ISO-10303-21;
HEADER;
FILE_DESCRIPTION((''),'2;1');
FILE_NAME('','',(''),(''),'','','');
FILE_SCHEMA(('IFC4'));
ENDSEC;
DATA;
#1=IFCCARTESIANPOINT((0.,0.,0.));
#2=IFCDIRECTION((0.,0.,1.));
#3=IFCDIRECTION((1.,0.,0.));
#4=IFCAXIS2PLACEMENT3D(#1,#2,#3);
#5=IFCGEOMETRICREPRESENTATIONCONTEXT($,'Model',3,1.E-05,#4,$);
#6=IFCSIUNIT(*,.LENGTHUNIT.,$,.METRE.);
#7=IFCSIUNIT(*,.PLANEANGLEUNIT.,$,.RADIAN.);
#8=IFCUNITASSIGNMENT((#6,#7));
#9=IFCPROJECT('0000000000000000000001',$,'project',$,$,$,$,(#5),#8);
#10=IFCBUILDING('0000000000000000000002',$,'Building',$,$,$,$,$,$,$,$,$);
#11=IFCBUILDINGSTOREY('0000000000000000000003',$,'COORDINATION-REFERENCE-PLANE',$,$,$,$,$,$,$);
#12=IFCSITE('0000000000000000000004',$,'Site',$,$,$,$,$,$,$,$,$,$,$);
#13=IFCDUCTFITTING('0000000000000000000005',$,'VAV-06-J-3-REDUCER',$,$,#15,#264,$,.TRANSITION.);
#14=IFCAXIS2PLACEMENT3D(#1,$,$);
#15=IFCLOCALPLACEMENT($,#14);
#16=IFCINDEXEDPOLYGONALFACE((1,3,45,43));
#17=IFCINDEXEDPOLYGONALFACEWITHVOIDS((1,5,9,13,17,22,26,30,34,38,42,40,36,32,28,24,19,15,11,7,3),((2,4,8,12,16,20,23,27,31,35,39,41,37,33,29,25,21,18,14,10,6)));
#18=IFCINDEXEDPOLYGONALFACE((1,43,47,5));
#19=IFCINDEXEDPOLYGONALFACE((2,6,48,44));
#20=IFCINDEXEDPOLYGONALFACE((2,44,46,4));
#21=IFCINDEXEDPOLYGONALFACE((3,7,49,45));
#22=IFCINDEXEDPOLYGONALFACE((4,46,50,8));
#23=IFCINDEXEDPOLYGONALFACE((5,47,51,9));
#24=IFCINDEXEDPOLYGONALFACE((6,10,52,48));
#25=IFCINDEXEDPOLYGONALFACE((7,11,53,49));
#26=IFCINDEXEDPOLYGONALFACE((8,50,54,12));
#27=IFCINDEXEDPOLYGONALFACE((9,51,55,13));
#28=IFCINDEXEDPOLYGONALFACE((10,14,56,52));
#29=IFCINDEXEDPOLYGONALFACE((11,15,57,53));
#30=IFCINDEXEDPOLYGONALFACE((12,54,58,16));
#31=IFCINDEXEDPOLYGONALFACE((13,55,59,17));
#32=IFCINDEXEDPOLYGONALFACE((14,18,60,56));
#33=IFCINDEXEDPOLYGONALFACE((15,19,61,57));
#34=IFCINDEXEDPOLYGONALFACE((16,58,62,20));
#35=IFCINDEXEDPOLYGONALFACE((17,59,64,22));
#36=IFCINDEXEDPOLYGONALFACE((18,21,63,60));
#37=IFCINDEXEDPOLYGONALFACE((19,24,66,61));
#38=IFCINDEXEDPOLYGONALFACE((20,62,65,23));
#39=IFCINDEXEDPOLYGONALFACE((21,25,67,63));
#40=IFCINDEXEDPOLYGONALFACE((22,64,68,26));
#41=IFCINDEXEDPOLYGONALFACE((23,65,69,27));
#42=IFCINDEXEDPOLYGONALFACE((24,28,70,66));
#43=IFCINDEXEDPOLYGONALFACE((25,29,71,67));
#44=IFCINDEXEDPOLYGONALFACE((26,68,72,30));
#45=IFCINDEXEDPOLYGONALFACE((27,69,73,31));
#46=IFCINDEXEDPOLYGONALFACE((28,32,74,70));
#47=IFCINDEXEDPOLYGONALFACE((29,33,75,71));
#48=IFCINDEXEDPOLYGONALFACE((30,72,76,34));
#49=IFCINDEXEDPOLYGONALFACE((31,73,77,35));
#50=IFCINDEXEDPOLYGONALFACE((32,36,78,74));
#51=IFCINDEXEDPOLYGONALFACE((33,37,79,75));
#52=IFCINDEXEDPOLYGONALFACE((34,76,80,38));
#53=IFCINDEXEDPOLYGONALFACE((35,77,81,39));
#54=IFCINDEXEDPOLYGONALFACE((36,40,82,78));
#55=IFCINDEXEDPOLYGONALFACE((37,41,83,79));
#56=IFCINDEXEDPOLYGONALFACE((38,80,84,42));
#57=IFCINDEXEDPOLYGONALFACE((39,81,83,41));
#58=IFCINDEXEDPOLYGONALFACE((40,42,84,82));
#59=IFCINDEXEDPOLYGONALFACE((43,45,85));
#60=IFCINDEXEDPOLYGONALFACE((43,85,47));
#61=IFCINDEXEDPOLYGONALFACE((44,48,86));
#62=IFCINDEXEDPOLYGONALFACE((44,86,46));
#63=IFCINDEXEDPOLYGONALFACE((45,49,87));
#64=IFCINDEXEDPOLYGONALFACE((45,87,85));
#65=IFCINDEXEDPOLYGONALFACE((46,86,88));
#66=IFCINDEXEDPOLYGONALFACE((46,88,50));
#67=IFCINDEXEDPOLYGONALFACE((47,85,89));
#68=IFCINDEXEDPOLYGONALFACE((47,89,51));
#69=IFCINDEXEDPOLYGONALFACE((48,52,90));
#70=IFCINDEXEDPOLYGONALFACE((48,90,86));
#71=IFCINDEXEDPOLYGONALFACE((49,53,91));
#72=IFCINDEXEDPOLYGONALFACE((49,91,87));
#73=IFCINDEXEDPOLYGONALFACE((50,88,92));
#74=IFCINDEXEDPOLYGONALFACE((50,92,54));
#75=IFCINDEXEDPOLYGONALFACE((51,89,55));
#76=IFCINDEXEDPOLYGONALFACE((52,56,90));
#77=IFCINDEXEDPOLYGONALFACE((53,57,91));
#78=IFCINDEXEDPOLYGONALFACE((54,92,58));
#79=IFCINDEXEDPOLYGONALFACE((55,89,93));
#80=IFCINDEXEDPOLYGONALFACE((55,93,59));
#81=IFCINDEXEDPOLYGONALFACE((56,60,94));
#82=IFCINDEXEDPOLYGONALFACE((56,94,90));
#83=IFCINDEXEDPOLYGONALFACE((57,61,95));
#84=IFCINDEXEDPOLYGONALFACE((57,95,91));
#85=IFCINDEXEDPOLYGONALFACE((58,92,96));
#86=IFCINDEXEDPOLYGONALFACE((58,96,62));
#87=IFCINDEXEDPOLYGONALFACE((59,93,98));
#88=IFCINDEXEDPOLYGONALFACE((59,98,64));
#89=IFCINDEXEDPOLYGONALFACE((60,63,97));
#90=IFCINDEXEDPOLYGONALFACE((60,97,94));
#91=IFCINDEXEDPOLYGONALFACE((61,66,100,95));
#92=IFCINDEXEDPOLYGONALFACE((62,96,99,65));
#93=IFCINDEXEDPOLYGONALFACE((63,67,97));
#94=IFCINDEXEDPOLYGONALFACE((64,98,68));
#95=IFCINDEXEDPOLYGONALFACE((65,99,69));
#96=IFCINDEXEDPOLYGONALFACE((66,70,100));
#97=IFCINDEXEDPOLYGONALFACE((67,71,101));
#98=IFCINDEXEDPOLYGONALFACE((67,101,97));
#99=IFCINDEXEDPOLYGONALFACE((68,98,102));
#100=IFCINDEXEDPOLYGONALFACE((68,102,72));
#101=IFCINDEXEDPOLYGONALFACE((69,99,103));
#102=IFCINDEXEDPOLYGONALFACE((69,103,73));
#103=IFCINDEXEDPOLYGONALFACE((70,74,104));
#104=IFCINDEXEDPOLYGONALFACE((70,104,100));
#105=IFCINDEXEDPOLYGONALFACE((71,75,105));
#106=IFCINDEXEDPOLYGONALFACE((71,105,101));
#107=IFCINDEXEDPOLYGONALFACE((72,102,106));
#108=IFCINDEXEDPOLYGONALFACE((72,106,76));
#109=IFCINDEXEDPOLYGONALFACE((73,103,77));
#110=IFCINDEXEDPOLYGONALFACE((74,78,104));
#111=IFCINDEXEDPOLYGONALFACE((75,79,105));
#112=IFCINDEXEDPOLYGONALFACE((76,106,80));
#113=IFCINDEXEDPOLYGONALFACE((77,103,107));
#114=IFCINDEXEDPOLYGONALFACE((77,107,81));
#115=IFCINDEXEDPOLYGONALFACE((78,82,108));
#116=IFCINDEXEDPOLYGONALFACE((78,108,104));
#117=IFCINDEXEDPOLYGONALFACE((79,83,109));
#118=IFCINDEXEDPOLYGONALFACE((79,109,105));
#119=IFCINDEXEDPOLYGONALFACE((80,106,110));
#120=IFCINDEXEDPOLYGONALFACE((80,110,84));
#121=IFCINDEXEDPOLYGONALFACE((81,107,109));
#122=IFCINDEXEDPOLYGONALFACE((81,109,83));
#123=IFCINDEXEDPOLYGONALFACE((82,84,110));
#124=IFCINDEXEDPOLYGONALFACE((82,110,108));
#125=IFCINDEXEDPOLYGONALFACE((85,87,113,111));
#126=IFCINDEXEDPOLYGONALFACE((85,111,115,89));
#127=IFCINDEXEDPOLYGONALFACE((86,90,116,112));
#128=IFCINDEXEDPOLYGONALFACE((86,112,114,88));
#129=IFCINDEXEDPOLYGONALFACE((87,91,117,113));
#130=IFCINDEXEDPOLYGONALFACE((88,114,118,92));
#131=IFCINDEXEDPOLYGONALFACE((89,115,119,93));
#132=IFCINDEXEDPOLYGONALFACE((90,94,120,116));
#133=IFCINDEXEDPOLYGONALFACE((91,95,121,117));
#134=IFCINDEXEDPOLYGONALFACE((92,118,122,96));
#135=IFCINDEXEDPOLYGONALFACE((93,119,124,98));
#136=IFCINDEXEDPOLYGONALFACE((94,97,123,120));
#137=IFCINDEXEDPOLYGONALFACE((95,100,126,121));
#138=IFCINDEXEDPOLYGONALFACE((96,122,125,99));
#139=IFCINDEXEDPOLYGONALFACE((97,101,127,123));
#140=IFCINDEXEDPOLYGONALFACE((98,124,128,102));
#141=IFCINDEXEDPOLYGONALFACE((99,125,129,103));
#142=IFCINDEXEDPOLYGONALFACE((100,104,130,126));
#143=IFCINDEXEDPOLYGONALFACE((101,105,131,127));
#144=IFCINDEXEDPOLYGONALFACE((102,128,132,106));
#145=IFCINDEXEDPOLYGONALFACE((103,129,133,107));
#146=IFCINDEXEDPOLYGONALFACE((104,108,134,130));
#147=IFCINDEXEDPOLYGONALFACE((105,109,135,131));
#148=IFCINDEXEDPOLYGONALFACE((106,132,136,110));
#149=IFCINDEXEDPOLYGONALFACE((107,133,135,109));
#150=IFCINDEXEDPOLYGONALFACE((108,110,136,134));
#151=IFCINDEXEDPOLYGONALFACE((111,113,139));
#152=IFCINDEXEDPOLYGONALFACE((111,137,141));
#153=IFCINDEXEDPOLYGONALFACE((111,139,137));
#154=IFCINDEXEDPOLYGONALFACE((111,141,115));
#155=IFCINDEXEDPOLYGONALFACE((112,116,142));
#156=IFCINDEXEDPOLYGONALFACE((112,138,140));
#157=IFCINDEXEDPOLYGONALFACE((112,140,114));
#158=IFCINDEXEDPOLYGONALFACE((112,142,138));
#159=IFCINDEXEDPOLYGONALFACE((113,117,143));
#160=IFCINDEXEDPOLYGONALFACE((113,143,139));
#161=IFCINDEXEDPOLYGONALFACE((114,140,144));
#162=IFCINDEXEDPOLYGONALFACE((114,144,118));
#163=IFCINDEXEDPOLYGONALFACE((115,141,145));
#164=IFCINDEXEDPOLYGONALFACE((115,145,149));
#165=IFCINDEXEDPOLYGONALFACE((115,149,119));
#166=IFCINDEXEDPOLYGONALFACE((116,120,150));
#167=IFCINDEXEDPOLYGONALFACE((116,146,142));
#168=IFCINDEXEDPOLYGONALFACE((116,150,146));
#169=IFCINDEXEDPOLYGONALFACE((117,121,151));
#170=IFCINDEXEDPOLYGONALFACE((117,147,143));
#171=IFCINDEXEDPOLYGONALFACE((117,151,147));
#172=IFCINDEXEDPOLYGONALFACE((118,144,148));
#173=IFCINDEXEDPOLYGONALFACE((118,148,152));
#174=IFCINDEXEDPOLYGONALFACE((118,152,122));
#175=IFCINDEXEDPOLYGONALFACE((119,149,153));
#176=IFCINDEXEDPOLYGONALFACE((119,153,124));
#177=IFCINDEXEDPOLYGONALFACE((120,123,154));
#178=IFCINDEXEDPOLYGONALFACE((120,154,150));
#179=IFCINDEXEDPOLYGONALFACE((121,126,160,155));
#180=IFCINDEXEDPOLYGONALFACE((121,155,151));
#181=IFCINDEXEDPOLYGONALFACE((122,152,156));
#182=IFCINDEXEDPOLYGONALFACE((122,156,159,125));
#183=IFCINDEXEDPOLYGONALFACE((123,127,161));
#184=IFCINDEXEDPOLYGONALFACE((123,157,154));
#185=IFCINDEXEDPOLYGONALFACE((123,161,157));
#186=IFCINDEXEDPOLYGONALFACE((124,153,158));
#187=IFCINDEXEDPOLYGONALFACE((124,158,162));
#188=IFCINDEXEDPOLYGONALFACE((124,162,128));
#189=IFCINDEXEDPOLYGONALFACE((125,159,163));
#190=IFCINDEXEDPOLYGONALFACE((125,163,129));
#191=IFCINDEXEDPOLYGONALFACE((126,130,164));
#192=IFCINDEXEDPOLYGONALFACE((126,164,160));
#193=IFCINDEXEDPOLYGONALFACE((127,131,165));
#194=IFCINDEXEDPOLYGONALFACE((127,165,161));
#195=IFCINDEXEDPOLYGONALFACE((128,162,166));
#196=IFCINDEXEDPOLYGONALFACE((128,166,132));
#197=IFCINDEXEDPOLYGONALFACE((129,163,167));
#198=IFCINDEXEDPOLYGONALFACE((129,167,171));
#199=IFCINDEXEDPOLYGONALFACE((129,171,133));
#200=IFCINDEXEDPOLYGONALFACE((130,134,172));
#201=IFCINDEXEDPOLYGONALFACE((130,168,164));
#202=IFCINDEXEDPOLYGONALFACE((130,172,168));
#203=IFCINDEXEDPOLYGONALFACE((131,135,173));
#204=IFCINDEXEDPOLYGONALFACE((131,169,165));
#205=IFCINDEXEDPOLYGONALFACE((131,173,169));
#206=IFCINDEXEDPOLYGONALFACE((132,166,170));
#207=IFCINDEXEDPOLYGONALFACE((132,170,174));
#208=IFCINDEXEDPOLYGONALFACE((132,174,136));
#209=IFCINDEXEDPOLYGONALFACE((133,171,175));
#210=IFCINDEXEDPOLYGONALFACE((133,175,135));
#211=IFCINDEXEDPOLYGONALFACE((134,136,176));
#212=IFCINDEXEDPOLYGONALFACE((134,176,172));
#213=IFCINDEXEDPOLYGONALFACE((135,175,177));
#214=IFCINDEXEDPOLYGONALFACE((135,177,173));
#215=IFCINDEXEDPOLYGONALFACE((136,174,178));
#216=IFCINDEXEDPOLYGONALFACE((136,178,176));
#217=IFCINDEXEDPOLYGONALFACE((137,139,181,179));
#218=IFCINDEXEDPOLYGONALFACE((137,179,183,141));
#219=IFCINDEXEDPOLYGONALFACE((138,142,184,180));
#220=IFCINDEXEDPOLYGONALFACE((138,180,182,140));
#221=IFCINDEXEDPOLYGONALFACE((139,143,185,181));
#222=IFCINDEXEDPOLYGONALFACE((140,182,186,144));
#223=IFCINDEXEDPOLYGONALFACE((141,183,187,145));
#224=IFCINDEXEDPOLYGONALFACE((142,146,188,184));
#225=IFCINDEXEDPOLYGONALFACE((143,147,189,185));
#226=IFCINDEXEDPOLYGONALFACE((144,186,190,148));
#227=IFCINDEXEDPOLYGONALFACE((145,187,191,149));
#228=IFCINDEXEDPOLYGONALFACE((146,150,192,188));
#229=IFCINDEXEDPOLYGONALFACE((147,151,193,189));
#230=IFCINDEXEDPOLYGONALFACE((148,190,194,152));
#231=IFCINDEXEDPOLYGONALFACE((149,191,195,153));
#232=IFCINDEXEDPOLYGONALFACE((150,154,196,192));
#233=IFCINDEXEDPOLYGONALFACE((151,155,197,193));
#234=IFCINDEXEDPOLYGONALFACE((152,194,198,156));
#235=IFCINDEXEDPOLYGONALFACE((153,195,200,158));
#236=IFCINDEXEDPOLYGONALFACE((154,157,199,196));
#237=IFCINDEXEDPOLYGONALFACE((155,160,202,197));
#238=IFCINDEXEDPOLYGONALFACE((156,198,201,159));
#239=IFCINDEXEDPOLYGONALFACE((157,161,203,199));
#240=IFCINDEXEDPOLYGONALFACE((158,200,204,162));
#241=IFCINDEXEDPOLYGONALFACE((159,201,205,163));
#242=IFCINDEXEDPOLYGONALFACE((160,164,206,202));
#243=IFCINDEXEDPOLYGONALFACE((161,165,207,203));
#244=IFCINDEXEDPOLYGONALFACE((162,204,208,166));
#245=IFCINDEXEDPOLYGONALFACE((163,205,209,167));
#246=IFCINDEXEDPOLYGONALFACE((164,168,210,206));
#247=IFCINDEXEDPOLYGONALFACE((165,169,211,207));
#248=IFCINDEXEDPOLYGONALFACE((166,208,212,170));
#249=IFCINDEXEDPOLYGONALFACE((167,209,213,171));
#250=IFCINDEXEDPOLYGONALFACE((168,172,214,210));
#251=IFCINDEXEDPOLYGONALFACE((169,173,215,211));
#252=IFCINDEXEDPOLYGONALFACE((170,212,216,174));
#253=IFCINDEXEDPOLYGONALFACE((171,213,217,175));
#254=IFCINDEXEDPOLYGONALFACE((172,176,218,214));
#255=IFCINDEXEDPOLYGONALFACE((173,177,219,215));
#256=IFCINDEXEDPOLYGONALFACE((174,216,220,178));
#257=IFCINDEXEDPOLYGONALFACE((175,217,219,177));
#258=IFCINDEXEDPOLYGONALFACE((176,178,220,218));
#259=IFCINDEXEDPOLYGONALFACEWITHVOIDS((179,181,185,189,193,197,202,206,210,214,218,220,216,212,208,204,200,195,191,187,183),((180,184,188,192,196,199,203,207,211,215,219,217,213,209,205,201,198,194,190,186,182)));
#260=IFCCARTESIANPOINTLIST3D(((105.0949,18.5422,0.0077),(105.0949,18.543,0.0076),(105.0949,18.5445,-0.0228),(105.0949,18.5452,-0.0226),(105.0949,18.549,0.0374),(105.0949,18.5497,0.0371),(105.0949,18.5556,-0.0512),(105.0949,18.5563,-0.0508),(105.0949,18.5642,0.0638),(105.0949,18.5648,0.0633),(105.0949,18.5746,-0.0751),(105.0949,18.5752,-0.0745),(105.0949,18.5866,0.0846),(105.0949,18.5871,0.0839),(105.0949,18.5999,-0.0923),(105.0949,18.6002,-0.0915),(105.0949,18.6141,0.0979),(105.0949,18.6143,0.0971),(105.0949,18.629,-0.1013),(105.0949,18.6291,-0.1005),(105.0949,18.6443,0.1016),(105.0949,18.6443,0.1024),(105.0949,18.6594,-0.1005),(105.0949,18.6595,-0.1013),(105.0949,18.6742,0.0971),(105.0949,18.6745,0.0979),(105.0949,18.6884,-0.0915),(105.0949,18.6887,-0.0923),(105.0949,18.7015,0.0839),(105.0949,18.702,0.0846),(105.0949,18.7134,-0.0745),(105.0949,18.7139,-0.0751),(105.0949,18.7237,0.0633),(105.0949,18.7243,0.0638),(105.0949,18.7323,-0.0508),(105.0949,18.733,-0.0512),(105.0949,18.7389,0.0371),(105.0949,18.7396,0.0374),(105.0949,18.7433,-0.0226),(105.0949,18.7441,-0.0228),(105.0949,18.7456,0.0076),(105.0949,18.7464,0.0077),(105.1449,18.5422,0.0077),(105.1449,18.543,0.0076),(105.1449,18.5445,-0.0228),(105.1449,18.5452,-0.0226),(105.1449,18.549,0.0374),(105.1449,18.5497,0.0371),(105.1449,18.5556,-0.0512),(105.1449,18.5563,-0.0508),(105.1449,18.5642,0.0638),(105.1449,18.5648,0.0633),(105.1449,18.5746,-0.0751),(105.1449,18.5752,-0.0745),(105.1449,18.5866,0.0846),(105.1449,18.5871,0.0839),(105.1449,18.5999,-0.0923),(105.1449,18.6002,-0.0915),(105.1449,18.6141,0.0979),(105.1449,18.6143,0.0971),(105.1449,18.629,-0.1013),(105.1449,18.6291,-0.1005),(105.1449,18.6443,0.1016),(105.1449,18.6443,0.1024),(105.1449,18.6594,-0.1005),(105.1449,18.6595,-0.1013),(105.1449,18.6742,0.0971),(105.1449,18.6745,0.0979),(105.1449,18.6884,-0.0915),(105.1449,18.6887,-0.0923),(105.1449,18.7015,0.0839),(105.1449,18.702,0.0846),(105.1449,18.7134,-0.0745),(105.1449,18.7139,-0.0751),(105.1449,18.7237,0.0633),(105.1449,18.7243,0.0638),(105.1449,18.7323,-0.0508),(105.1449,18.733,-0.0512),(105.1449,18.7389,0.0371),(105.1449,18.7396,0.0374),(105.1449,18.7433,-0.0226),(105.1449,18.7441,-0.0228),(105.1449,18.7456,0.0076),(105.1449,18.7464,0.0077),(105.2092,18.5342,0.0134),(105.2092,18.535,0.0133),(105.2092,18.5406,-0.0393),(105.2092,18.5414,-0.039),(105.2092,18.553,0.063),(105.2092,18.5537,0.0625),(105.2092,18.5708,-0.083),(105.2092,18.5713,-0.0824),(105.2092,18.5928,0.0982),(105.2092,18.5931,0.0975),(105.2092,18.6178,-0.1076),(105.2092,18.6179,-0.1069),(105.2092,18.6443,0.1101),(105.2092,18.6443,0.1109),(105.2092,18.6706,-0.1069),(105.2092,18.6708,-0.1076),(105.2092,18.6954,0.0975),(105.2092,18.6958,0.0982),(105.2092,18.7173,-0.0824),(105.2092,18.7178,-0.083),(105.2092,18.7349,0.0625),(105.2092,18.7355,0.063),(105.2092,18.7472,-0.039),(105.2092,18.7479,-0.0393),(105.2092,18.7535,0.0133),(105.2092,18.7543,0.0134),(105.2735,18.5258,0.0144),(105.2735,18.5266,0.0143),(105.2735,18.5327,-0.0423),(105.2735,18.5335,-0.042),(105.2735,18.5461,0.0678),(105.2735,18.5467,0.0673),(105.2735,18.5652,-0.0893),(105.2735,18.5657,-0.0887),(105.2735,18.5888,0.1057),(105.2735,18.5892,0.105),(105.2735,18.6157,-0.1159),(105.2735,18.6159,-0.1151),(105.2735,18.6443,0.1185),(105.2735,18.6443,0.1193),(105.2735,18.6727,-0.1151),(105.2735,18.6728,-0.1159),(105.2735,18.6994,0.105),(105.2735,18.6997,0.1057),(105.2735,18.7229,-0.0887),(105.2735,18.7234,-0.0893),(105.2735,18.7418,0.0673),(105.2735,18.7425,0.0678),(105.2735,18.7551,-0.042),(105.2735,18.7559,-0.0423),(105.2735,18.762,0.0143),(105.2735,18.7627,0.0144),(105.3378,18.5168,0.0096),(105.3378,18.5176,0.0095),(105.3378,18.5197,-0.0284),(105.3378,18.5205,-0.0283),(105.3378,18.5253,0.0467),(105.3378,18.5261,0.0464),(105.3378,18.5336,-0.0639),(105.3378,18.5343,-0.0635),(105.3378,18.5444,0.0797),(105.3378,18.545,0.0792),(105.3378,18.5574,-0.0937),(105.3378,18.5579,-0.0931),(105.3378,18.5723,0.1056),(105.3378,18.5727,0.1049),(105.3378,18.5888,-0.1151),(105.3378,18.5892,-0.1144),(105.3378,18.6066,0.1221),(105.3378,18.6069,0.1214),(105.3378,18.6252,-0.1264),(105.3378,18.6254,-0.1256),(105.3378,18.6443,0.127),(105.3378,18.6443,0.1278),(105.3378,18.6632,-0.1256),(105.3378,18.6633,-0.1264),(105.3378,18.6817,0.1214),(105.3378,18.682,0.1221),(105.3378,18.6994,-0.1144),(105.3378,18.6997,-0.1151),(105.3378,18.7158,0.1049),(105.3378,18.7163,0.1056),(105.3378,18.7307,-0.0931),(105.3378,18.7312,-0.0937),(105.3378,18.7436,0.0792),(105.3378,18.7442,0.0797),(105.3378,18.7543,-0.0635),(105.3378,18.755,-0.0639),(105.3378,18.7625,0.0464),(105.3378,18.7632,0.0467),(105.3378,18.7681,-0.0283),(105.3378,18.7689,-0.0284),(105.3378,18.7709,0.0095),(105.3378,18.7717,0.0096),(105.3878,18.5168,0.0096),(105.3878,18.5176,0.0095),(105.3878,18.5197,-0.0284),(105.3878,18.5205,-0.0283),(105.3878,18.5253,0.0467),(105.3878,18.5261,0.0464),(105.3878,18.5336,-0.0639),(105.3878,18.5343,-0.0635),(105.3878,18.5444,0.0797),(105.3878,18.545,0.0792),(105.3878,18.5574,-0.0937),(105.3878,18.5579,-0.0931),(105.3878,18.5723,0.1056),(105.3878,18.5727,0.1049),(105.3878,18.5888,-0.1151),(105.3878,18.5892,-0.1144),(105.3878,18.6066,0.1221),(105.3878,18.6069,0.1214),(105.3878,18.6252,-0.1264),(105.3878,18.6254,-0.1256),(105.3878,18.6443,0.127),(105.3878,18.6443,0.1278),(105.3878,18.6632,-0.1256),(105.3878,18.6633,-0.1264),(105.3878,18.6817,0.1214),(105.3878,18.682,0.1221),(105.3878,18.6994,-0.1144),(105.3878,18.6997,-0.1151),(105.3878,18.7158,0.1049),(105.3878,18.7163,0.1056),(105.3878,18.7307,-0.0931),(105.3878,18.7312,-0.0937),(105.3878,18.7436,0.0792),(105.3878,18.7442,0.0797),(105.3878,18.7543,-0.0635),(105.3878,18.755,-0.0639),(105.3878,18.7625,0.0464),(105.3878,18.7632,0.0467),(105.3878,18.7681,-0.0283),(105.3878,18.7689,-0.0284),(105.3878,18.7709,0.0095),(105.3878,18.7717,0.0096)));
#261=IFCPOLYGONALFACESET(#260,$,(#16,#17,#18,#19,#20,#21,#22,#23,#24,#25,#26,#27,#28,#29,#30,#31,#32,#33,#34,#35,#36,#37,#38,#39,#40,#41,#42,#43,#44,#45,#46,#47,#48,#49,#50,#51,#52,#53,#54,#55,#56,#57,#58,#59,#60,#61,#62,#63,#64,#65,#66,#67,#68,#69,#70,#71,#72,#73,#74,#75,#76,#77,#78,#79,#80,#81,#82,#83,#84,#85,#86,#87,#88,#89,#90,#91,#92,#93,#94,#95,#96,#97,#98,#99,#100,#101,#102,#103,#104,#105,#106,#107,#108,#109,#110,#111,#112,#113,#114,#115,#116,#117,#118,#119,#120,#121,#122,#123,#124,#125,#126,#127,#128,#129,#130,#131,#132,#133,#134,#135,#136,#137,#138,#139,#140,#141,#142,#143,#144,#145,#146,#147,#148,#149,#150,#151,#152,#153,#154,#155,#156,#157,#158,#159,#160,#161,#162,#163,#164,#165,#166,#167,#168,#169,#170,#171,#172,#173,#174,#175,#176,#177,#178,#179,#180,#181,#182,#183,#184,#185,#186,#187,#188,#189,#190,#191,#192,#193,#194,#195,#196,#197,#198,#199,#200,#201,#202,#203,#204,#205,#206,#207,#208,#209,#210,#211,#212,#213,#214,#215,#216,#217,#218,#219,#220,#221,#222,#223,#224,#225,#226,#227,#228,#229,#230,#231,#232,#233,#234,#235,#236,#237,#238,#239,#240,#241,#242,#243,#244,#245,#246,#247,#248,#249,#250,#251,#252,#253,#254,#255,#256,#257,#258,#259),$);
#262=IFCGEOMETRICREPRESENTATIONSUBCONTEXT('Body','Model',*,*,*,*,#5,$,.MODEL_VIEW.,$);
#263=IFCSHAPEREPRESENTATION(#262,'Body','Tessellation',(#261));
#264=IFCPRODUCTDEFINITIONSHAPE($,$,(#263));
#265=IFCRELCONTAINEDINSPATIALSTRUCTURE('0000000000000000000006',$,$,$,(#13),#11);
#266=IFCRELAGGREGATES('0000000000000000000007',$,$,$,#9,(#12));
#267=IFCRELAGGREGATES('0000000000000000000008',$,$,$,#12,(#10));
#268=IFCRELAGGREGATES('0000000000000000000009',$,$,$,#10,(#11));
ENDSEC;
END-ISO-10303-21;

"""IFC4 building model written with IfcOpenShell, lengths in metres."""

from ifc_helpers import new_model, entity, si_unit, frame, origin_with_axes, place, context, subcontext, project, spatial, element, save


model = new_model("IFC4")

# Units and contexts
model_context = context("Model", 3, precision=1e-05, world=origin_with_axes())
body_context_1 = subcontext(model_context, "Body", "Model", "MODEL_VIEW")
ifc_project = project(units=[si_unit("LENGTHUNIT", "METRE"), si_unit("PLANEANGLEUNIT", "RADIAN")], contexts=[model_context])

# Site, building, storey
site = spatial("IfcSite", under=ifc_project, Name="Site")
building = spatial("IfcBuilding", under=site, Name="Building")
storey = spatial("IfcBuildingStorey", under=building, Name="COORDINATION-REFERENCE-PLANE")

# Duct fitting
for number, where, z_axis, x_axis, name in (
    (1, (105.3878, 18.6443, 0.0), (0.0, -1.0, 0.0), (0.0, 0.0, 1.0), "VAV-06-J-3-REDUCER"),
):
    element("IfcDuctFitting", number, at=place(None, frame(where, z_axis=z_axis, x_axis=x_axis)), inside=storey, Name=name, PredefinedType="TRANSITION", context=body_context_1, shape_type="SweptSolid", body=[
        entity("IfcRevolvedAreaSolid", entity("IfcArbitraryClosedProfileDef", "AREA", None, entity("IfcPolyline", [entity("IfcCartesianPoint", [0.1278, 0.0]), entity("IfcCartesianPoint", [0.1278, 0.05]), entity("IfcCartesianPoint", [0.1024, 0.2429]), entity("IfcCartesianPoint", [0.1024, 0.2929]), entity("IfcCartesianPoint", [0.1016, 0.2929]), entity("IfcCartesianPoint", [0.1016, 0.2429]), entity("IfcCartesianPoint", [0.127, 0.05]), entity("IfcCartesianPoint", [0.127, 0.0]), entity("IfcCartesianPoint", [0.1278, 0.0])])), entity("IfcAxis2Placement3D", entity("IfcCartesianPoint", [0.0, 0.0, 0.0])), entity("IfcAxis1Placement", entity("IfcCartesianPoint", [0.0, 0.0, 0.0]), entity("IfcDirection", [0.0, 1.0, 0.0])), 6.283185),
    ])

save(model, "model.ifc")
